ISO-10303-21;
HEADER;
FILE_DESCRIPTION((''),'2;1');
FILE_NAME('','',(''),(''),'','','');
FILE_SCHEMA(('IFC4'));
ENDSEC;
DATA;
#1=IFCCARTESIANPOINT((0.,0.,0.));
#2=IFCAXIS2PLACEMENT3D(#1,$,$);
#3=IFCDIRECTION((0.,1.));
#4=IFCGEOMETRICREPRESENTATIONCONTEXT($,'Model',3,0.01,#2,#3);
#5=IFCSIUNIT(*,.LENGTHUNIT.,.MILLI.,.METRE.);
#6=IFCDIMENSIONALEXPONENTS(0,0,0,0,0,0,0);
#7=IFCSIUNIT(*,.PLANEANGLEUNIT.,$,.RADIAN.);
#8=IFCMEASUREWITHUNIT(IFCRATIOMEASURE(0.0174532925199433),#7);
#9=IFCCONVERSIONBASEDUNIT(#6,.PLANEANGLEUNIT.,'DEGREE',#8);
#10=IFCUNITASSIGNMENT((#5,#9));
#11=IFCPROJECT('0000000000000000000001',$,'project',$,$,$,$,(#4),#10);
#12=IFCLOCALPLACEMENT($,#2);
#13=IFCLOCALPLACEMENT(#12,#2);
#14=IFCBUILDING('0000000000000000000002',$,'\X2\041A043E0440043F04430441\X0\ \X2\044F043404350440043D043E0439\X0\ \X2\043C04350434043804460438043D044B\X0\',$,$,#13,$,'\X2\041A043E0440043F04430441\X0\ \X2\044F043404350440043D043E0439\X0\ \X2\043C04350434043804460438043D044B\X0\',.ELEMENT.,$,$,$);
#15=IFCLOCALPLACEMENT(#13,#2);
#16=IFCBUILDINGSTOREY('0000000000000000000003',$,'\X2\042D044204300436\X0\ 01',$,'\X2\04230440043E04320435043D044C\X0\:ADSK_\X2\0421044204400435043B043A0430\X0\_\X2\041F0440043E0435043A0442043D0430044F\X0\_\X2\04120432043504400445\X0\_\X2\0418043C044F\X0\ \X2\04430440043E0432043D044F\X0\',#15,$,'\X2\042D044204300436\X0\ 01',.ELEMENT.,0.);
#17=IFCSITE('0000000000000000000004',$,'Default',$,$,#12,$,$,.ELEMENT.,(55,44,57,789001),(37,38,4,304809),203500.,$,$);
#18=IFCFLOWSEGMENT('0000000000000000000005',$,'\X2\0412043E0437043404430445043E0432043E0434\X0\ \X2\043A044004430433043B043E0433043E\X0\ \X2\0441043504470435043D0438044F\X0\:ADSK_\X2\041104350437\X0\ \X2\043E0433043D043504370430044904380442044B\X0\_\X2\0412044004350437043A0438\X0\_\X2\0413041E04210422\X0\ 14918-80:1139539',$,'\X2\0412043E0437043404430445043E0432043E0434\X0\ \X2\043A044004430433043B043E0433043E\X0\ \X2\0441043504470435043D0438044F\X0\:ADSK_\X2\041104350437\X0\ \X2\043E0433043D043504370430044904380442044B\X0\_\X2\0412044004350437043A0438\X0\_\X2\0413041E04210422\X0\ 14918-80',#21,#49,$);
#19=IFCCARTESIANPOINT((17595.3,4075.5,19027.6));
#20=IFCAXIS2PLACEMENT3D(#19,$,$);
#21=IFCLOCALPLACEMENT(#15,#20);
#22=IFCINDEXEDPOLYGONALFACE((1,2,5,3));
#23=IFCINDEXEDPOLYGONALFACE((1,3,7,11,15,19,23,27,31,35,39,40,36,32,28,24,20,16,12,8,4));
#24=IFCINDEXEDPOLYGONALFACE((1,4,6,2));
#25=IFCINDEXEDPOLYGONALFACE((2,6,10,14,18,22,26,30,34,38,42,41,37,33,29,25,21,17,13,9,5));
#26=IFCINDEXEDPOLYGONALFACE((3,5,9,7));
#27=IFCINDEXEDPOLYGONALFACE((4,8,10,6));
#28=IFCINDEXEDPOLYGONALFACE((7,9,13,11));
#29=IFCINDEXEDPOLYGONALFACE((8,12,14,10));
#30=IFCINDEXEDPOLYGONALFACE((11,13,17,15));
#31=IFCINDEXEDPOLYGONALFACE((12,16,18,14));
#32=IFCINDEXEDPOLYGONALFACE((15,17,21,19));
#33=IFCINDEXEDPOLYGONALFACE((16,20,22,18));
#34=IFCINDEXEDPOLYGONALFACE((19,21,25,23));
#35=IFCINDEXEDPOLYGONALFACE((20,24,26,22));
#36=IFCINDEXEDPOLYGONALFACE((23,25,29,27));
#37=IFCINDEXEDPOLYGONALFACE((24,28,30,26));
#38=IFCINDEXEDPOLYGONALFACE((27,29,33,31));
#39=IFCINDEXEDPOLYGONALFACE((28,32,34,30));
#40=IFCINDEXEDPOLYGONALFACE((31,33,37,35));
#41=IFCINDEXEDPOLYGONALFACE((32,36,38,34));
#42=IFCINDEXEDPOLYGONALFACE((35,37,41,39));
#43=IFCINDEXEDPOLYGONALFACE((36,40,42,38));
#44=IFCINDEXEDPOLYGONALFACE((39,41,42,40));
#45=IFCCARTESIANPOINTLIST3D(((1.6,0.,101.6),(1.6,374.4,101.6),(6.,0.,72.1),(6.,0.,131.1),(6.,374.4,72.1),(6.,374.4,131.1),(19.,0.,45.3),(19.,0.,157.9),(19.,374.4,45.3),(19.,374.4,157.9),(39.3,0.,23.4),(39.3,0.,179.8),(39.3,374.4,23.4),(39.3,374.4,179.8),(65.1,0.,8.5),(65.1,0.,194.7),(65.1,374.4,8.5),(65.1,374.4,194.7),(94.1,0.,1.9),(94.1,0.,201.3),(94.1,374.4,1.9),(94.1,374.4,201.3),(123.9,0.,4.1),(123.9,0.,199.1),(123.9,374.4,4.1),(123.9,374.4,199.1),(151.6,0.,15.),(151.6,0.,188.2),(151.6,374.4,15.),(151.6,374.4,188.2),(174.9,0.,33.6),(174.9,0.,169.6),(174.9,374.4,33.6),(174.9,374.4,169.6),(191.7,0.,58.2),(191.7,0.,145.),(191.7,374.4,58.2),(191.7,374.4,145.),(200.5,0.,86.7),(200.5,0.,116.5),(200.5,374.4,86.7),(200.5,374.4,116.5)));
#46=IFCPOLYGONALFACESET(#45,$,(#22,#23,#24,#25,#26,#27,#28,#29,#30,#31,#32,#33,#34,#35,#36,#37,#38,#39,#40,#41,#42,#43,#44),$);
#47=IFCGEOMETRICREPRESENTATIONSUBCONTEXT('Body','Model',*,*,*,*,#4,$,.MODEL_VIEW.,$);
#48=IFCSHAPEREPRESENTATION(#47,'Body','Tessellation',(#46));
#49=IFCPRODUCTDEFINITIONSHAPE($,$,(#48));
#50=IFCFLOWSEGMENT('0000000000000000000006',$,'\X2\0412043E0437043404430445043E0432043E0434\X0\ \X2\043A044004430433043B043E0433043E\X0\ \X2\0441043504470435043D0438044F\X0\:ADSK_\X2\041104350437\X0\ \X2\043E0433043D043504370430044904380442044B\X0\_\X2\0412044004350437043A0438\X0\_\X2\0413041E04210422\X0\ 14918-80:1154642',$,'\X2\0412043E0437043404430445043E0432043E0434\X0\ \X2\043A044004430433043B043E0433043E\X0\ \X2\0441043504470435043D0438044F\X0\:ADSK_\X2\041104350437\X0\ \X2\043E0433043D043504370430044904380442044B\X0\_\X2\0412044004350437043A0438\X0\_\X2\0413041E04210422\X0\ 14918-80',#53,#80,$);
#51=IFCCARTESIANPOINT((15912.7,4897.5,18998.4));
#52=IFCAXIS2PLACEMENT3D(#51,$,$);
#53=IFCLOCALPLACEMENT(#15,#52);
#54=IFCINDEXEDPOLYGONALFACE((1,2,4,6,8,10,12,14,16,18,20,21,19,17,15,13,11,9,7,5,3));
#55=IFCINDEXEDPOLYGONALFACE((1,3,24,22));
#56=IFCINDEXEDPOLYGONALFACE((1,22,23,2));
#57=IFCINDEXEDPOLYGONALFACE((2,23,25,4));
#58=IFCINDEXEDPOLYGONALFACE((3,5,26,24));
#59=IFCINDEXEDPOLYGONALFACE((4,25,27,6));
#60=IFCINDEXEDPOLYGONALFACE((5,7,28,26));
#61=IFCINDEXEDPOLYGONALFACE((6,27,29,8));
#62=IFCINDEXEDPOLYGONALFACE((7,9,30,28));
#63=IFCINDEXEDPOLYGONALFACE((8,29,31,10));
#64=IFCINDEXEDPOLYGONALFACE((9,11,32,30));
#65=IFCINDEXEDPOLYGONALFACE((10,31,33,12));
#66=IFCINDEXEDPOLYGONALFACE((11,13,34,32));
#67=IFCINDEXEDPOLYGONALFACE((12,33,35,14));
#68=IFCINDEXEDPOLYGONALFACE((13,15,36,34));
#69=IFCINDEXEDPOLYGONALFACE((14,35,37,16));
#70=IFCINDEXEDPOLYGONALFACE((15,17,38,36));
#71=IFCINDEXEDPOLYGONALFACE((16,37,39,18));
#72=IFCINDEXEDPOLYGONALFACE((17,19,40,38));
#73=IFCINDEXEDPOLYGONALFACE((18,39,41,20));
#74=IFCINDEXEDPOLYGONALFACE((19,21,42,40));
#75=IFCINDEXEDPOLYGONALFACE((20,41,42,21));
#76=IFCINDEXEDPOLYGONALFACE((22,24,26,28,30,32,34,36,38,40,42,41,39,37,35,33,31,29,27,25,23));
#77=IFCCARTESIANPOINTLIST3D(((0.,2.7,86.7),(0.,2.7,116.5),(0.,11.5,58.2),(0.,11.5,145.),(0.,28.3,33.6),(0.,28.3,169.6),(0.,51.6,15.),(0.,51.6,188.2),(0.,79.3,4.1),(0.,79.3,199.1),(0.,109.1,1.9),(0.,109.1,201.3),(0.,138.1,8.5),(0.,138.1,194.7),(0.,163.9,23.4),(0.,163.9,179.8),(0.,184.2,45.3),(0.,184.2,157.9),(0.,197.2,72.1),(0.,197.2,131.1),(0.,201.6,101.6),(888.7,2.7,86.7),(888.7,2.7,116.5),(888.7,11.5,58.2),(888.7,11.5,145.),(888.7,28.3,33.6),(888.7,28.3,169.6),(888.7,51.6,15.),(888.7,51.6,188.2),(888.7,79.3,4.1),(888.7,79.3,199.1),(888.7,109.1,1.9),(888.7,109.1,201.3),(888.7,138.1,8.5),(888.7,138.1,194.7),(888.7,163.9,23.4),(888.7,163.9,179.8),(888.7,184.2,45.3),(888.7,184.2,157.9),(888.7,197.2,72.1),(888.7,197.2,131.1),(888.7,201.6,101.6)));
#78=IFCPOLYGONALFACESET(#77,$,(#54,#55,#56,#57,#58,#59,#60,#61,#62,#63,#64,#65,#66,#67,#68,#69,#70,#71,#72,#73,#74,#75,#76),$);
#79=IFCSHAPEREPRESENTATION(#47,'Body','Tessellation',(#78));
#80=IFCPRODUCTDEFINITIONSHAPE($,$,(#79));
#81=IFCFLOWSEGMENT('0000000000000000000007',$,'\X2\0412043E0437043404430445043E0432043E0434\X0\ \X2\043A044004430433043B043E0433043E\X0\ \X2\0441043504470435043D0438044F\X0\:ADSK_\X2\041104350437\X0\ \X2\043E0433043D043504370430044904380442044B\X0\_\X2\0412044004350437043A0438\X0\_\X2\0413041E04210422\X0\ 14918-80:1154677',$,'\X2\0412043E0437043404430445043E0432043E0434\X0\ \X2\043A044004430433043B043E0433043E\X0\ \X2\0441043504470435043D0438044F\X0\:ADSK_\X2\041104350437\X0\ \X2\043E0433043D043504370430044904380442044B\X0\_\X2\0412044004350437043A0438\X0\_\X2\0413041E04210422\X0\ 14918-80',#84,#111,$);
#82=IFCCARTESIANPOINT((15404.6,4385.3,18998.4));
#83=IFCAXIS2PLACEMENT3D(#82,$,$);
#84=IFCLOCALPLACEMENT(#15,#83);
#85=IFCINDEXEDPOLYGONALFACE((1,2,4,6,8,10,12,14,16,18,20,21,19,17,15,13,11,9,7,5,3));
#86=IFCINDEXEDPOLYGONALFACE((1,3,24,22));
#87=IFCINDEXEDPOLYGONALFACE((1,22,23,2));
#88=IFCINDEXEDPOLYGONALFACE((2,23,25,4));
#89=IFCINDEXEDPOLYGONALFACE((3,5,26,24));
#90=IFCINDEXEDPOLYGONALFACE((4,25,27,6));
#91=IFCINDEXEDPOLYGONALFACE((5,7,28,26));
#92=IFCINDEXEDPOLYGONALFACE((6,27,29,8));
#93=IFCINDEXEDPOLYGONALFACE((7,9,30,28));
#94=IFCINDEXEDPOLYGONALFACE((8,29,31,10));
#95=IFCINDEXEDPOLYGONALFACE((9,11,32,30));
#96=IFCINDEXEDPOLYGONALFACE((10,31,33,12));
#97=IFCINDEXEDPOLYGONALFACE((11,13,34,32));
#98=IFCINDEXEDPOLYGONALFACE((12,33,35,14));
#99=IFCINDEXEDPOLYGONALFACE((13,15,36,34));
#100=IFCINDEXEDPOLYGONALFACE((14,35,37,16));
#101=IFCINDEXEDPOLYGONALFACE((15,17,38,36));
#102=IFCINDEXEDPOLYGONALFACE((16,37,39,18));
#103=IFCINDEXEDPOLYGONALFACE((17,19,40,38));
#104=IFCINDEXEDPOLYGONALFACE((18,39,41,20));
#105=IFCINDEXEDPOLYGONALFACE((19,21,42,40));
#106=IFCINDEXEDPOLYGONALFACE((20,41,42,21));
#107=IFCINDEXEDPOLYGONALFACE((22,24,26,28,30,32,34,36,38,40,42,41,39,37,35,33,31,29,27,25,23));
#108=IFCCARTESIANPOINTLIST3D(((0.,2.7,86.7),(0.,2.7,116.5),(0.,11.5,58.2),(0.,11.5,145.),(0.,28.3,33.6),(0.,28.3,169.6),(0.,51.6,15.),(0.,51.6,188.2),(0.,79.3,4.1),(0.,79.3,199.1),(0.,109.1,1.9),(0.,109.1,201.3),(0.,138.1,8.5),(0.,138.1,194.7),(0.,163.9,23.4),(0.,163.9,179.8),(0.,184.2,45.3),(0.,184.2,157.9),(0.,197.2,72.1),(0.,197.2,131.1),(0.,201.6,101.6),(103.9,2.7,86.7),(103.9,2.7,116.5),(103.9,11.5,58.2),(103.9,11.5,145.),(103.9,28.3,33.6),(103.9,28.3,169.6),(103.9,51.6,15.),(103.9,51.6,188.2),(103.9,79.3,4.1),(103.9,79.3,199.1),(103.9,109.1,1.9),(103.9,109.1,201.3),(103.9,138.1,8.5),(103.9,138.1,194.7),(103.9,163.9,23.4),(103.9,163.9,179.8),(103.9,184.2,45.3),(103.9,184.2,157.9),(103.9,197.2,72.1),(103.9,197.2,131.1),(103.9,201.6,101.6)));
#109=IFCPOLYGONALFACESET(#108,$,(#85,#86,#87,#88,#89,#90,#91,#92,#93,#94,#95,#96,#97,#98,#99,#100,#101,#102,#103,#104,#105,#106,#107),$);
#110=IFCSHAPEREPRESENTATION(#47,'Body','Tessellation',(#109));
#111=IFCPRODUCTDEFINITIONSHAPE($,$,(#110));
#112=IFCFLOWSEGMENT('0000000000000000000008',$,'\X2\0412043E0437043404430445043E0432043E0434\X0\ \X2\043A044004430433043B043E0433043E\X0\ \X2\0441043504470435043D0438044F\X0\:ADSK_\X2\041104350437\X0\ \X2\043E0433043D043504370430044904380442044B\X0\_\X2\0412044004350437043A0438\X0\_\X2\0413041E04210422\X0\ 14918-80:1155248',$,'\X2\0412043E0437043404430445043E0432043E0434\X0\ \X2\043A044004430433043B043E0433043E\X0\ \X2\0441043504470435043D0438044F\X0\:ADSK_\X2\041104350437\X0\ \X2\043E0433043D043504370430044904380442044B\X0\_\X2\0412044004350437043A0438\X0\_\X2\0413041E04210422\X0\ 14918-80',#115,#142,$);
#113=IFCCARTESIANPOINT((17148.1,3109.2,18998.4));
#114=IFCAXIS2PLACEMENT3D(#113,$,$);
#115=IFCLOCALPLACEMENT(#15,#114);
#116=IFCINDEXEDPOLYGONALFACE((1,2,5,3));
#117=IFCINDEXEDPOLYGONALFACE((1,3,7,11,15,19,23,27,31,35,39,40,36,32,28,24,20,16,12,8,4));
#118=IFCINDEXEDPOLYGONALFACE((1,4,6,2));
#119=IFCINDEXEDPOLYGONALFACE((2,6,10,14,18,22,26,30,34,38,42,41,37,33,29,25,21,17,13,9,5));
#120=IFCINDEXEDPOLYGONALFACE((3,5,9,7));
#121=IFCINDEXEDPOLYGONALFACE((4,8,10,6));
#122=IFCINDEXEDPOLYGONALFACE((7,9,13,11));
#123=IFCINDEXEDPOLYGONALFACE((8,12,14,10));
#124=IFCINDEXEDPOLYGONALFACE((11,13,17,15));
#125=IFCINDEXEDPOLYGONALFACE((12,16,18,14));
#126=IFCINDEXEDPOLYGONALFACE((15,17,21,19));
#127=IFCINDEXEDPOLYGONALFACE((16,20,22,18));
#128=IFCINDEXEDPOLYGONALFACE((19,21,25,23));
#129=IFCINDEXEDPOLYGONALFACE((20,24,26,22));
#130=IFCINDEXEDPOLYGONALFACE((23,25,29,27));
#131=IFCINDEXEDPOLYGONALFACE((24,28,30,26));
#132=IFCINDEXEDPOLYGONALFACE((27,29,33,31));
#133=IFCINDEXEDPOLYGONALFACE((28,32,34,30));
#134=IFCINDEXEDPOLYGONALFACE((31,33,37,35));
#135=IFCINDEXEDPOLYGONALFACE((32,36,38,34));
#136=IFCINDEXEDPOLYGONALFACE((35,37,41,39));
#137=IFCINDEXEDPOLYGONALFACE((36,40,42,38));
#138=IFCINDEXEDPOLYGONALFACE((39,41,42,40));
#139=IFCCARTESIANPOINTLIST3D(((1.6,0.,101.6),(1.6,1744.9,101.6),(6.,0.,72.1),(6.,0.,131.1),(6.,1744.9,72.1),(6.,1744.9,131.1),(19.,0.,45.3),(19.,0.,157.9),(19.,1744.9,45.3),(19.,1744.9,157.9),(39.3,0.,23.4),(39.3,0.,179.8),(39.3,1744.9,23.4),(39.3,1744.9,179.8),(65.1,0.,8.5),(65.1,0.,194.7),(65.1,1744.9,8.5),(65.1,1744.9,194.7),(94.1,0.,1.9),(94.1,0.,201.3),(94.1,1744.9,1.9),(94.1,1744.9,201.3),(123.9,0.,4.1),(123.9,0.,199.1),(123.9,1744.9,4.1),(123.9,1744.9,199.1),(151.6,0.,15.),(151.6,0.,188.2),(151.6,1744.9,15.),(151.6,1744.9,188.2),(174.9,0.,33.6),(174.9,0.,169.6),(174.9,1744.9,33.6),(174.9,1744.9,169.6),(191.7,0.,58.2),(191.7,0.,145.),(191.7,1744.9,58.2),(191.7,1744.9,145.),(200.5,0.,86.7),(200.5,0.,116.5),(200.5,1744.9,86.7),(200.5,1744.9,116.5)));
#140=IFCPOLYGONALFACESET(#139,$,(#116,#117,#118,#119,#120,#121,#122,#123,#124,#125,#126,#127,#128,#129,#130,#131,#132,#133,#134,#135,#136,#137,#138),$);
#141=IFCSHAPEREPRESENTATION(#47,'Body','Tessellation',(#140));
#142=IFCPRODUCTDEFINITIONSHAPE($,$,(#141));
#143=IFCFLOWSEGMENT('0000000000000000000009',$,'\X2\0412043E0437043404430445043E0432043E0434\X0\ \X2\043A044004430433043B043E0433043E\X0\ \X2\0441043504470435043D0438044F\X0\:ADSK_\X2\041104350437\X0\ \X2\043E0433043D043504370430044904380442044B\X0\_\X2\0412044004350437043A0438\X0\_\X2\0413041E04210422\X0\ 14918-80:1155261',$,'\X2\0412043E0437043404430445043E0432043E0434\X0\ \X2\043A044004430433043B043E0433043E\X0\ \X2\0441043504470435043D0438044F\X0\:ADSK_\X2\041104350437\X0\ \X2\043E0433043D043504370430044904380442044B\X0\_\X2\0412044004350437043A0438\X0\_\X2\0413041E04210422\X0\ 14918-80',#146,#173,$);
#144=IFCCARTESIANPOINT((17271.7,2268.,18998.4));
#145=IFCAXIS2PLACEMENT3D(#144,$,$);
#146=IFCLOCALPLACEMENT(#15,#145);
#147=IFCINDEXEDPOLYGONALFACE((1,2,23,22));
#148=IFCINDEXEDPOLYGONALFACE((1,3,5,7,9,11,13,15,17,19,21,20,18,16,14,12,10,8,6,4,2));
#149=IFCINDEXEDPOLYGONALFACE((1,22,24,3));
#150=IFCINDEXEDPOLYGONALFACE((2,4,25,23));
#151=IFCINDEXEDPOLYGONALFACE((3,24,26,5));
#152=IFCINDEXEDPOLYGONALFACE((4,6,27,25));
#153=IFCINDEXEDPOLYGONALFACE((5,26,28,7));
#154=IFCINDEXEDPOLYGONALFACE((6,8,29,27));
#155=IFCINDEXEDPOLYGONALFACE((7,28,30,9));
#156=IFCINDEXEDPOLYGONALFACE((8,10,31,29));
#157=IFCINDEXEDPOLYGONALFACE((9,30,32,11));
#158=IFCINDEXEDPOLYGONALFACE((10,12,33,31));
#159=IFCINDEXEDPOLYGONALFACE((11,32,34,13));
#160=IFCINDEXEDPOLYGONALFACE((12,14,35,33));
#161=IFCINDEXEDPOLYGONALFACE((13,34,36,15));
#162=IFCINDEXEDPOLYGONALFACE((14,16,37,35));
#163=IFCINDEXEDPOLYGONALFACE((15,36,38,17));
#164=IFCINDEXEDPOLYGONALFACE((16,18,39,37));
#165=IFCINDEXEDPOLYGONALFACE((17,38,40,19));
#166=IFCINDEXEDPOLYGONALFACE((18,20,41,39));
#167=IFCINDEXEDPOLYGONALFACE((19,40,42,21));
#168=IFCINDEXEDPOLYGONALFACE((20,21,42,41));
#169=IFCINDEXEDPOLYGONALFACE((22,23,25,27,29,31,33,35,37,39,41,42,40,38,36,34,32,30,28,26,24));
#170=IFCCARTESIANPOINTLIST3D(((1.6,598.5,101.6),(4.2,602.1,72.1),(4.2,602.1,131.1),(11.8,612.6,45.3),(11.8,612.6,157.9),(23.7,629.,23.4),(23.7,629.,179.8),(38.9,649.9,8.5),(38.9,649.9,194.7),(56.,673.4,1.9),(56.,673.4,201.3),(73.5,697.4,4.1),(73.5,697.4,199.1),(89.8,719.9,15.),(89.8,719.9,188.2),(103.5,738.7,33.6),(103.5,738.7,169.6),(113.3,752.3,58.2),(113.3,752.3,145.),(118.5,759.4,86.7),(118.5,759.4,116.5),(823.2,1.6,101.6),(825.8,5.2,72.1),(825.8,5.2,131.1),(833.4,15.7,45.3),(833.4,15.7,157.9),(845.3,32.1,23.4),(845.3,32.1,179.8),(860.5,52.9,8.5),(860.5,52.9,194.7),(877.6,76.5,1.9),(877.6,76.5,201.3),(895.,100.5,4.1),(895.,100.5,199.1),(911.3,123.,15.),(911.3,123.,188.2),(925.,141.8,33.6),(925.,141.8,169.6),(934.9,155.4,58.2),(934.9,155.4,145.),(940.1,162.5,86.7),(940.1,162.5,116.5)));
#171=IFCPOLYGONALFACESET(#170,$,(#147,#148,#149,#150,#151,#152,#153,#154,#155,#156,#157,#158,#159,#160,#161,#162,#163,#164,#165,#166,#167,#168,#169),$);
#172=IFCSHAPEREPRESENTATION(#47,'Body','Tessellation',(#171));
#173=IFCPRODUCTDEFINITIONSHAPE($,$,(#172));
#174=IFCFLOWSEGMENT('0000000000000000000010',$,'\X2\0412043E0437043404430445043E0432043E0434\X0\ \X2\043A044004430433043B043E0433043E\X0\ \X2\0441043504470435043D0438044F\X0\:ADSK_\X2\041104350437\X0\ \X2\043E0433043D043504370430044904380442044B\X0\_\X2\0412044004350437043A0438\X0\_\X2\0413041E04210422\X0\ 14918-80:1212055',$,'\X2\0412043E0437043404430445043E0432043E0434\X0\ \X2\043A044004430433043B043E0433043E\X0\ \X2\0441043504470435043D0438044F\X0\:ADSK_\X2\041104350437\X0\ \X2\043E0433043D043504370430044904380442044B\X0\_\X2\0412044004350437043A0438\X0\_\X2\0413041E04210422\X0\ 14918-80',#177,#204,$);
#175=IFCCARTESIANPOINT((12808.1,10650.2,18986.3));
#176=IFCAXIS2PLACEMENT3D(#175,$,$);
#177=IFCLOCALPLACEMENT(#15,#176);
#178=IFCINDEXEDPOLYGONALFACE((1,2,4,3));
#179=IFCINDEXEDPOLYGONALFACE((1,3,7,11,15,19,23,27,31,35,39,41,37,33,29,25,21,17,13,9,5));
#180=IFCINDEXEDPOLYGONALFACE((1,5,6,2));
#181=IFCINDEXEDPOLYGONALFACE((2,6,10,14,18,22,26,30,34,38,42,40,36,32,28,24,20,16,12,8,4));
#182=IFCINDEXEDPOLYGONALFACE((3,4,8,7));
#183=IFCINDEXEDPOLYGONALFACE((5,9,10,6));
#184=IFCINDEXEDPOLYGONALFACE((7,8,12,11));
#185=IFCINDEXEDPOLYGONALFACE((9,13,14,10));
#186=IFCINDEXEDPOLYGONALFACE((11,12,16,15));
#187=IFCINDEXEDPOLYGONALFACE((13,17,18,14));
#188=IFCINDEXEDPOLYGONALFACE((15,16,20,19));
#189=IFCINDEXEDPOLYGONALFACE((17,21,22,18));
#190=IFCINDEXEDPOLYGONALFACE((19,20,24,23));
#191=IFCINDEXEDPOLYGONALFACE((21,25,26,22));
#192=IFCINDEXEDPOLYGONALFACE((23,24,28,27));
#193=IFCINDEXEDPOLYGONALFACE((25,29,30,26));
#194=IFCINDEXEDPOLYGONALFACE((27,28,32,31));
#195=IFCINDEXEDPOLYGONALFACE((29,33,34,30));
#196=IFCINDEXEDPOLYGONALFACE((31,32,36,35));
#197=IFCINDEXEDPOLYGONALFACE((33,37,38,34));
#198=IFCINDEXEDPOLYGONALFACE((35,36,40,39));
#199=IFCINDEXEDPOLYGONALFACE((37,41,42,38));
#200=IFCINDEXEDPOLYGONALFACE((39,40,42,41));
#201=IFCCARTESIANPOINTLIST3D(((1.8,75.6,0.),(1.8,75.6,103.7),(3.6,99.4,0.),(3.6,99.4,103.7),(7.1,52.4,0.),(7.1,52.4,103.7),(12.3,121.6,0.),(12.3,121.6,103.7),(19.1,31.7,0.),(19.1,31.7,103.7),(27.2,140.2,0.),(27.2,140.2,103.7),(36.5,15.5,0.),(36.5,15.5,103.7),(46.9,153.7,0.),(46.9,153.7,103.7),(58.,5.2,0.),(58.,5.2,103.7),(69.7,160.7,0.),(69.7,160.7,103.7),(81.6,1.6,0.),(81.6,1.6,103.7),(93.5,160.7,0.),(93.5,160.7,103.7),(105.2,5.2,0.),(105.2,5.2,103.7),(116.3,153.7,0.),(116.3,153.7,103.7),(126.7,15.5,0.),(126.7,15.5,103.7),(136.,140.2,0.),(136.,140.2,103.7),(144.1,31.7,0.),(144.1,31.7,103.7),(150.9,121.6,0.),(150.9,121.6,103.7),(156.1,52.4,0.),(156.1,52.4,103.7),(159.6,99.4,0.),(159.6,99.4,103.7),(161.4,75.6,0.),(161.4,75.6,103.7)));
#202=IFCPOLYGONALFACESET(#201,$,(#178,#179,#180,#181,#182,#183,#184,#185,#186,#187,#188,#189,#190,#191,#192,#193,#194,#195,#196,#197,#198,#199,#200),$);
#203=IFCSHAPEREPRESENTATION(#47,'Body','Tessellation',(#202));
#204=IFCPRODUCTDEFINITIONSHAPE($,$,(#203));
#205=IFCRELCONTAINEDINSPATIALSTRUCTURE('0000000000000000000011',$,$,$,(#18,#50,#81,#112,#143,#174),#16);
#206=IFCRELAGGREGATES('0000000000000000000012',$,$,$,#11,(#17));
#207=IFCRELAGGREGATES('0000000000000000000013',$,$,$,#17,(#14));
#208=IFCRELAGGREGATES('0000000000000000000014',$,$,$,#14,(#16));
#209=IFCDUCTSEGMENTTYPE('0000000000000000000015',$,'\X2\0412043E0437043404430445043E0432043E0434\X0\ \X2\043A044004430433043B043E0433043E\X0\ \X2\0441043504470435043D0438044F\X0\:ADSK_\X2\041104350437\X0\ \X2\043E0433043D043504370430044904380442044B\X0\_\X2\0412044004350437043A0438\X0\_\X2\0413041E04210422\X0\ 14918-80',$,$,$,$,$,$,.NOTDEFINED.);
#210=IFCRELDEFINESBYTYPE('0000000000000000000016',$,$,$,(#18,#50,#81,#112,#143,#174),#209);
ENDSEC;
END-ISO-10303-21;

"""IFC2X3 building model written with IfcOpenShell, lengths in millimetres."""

from ifc_helpers import new_model, entity, si_unit, converted_unit, direction, frame, origin, origin_2d_with_axis, place, context, subcontext, project, spatial, circle, extrude, type_object, element, save


model = new_model("IFC2X3")

# Units and contexts
model_context = context("Model", 3, precision=0.01, world=origin(), true_north=direction((0.0, 1.0)))
body_context = subcontext(model_context, "Body", "Model", "MODEL_VIEW")
ifc_project = project(units=[si_unit("LENGTHUNIT", "METRE", prefix="MILLI"), converted_unit("PLANEANGLEUNIT", "DEGREE", entity("IfcRatioMeasure", 0.0174532925199433), si_unit("PLANEANGLEUNIT", "RADIAN"), dimensions=[0, 0, 0, 0, 0, 0, 0])], contexts=[model_context])

# Site, building, storey
site_placement = place(None, origin())
site = spatial("IfcSite", under=ifc_project, at=site_placement, Name="Default", CompositionType="ELEMENT", RefLatitude=(55, 44, 57, 789001), RefLongitude=(37, 38, 4, 304809), RefElevation=203500.0)
building_placement = place(site_placement, origin())
building = spatial("IfcBuilding", under=site, at=building_placement, Name="Корпус ядерной медицины", LongName="Корпус ядерной медицины", CompositionType="ELEMENT")
storey_placement = place(building_placement, origin())
storey = spatial("IfcBuildingStorey", under=building, at=storey_placement, Name="Этаж 01", ObjectType="Уровень:ADSK_Стрелка_Проектная_Вверх_Имя уровня", LongName="Этаж 01", CompositionType="ELEMENT", Elevation=0.0)

# Flow segments
duct_segment_type_1 = type_object("IfcDuctSegmentType", Name="Воздуховод круглого сечения:ADSK_Без огнезащиты_Врезки_ГОСТ 14918-80", PredefinedType="NOTDEFINED")
flow_segment_1_placement = place(storey_placement, frame((17595.3, 4075.5, 19027.6)))
element("IfcFlowSegment", 1, at=flow_segment_1_placement, inside=storey, type_object=duct_segment_type_1, Name="Воздуховод круглого сечения:ADSK_Без огнезащиты_Врезки_ГОСТ 14918-80:1139539", ObjectType="Воздуховод круглого сечения:ADSK_Без огнезащиты_Врезки_ГОСТ 14918-80", context=body_context, shape_type="SweptSolid", body=[
    extrude(circle(Radius=100.0, at=origin_2d_with_axis()), frame((101.6, 0.0, 101.6), z_axis=(0.0, 1.0, 0.0), x_axis=(-1.0, 0.0, 0.0)), (0.0, 0.0, 1.0), 374.4),
])
flow_segment_2_placement = place(storey_placement, frame((15912.7, 4897.5, 18998.4)))
element("IfcFlowSegment", 2, at=flow_segment_2_placement, inside=storey, type_object=duct_segment_type_1, Name="Воздуховод круглого сечения:ADSK_Без огнезащиты_Врезки_ГОСТ 14918-80:1154642", ObjectType="Воздуховод круглого сечения:ADSK_Без огнезащиты_Врезки_ГОСТ 14918-80", context=body_context, shape_type="SweptSolid", body=[
    extrude(circle(Radius=100.0, at=origin_2d_with_axis()), frame((0.0, 101.6, 101.6), z_axis=(1.0, 0.0, 0.0), x_axis=(0.0, 1.0, 0.0)), (0.0, 0.0, 1.0), 888.7),
])
flow_segment_3_placement = place(storey_placement, frame((15404.6, 4385.3, 18998.4)))
element("IfcFlowSegment", 3, at=flow_segment_3_placement, inside=storey, type_object=duct_segment_type_1, Name="Воздуховод круглого сечения:ADSK_Без огнезащиты_Врезки_ГОСТ 14918-80:1154677", ObjectType="Воздуховод круглого сечения:ADSK_Без огнезащиты_Врезки_ГОСТ 14918-80", context=body_context, shape_type="SweptSolid", body=[
    extrude(circle(Radius=100.0, at=origin_2d_with_axis()), frame((0.0, 101.6, 101.6), z_axis=(1.0, 0.0, 0.0), x_axis=(0.0, 1.0, 0.0)), (0.0, 0.0, 1.0), 103.9),
])
flow_segment_4_placement = place(storey_placement, frame((17148.1, 3109.2, 18998.4)))
element("IfcFlowSegment", 4, at=flow_segment_4_placement, inside=storey, type_object=duct_segment_type_1, Name="Воздуховод круглого сечения:ADSK_Без огнезащиты_Врезки_ГОСТ 14918-80:1155248", ObjectType="Воздуховод круглого сечения:ADSK_Без огнезащиты_Врезки_ГОСТ 14918-80", context=body_context, shape_type="SweptSolid", body=[
    extrude(circle(Radius=100.0, at=origin_2d_with_axis()), frame((101.6, 0.0, 101.6), z_axis=(0.0, 1.0, 0.0), x_axis=(-1.0, 0.0, 0.0)), (0.0, 0.0, 1.0), 1744.9),
])
flow_segment_5_placement = place(storey_placement, frame((17271.7, 2268.0, 18998.4)))
element("IfcFlowSegment", 5, at=flow_segment_5_placement, inside=storey, type_object=duct_segment_type_1, Name="Воздуховод круглого сечения:ADSK_Без огнезащиты_Врезки_ГОСТ 14918-80:1155261", ObjectType="Воздуховод круглого сечения:ADSK_Без огнезащиты_Врезки_ГОСТ 14918-80", context=body_context, shape_type="SweptSolid", body=[
    extrude(circle(Radius=100.0, at=origin_2d_with_axis()), frame((882.0, 82.5, 101.6), z_axis=(-0.809017, 0.587785, 0.0), x_axis=(-0.587785, -0.809017, 0.0)), (0.0, 0.0, 1.0), 1015.5),
])
flow_segment_6_placement = place(storey_placement, frame((12808.1, 10650.2, 18986.3)))
element("IfcFlowSegment", 6, at=flow_segment_6_placement, inside=storey, type_object=duct_segment_type_1, Name="Воздуховод круглого сечения:ADSK_Без огнезащиты_Врезки_ГОСТ 14918-80:1212055", ObjectType="Воздуховод круглого сечения:ADSK_Без огнезащиты_Врезки_ГОСТ 14918-80", context=body_context, shape_type="SweptSolid", body=[
    extrude(circle(Radius=80.0, at=origin_2d_with_axis()), frame((81.6, 81.6, 0.0), z_axis=(0.0, 0.0, 1.0), x_axis=(0.0, -1.0, 0.0)), (0.0, 0.0, 1.0), 103.7),
])

save(model, "model.ifc")
